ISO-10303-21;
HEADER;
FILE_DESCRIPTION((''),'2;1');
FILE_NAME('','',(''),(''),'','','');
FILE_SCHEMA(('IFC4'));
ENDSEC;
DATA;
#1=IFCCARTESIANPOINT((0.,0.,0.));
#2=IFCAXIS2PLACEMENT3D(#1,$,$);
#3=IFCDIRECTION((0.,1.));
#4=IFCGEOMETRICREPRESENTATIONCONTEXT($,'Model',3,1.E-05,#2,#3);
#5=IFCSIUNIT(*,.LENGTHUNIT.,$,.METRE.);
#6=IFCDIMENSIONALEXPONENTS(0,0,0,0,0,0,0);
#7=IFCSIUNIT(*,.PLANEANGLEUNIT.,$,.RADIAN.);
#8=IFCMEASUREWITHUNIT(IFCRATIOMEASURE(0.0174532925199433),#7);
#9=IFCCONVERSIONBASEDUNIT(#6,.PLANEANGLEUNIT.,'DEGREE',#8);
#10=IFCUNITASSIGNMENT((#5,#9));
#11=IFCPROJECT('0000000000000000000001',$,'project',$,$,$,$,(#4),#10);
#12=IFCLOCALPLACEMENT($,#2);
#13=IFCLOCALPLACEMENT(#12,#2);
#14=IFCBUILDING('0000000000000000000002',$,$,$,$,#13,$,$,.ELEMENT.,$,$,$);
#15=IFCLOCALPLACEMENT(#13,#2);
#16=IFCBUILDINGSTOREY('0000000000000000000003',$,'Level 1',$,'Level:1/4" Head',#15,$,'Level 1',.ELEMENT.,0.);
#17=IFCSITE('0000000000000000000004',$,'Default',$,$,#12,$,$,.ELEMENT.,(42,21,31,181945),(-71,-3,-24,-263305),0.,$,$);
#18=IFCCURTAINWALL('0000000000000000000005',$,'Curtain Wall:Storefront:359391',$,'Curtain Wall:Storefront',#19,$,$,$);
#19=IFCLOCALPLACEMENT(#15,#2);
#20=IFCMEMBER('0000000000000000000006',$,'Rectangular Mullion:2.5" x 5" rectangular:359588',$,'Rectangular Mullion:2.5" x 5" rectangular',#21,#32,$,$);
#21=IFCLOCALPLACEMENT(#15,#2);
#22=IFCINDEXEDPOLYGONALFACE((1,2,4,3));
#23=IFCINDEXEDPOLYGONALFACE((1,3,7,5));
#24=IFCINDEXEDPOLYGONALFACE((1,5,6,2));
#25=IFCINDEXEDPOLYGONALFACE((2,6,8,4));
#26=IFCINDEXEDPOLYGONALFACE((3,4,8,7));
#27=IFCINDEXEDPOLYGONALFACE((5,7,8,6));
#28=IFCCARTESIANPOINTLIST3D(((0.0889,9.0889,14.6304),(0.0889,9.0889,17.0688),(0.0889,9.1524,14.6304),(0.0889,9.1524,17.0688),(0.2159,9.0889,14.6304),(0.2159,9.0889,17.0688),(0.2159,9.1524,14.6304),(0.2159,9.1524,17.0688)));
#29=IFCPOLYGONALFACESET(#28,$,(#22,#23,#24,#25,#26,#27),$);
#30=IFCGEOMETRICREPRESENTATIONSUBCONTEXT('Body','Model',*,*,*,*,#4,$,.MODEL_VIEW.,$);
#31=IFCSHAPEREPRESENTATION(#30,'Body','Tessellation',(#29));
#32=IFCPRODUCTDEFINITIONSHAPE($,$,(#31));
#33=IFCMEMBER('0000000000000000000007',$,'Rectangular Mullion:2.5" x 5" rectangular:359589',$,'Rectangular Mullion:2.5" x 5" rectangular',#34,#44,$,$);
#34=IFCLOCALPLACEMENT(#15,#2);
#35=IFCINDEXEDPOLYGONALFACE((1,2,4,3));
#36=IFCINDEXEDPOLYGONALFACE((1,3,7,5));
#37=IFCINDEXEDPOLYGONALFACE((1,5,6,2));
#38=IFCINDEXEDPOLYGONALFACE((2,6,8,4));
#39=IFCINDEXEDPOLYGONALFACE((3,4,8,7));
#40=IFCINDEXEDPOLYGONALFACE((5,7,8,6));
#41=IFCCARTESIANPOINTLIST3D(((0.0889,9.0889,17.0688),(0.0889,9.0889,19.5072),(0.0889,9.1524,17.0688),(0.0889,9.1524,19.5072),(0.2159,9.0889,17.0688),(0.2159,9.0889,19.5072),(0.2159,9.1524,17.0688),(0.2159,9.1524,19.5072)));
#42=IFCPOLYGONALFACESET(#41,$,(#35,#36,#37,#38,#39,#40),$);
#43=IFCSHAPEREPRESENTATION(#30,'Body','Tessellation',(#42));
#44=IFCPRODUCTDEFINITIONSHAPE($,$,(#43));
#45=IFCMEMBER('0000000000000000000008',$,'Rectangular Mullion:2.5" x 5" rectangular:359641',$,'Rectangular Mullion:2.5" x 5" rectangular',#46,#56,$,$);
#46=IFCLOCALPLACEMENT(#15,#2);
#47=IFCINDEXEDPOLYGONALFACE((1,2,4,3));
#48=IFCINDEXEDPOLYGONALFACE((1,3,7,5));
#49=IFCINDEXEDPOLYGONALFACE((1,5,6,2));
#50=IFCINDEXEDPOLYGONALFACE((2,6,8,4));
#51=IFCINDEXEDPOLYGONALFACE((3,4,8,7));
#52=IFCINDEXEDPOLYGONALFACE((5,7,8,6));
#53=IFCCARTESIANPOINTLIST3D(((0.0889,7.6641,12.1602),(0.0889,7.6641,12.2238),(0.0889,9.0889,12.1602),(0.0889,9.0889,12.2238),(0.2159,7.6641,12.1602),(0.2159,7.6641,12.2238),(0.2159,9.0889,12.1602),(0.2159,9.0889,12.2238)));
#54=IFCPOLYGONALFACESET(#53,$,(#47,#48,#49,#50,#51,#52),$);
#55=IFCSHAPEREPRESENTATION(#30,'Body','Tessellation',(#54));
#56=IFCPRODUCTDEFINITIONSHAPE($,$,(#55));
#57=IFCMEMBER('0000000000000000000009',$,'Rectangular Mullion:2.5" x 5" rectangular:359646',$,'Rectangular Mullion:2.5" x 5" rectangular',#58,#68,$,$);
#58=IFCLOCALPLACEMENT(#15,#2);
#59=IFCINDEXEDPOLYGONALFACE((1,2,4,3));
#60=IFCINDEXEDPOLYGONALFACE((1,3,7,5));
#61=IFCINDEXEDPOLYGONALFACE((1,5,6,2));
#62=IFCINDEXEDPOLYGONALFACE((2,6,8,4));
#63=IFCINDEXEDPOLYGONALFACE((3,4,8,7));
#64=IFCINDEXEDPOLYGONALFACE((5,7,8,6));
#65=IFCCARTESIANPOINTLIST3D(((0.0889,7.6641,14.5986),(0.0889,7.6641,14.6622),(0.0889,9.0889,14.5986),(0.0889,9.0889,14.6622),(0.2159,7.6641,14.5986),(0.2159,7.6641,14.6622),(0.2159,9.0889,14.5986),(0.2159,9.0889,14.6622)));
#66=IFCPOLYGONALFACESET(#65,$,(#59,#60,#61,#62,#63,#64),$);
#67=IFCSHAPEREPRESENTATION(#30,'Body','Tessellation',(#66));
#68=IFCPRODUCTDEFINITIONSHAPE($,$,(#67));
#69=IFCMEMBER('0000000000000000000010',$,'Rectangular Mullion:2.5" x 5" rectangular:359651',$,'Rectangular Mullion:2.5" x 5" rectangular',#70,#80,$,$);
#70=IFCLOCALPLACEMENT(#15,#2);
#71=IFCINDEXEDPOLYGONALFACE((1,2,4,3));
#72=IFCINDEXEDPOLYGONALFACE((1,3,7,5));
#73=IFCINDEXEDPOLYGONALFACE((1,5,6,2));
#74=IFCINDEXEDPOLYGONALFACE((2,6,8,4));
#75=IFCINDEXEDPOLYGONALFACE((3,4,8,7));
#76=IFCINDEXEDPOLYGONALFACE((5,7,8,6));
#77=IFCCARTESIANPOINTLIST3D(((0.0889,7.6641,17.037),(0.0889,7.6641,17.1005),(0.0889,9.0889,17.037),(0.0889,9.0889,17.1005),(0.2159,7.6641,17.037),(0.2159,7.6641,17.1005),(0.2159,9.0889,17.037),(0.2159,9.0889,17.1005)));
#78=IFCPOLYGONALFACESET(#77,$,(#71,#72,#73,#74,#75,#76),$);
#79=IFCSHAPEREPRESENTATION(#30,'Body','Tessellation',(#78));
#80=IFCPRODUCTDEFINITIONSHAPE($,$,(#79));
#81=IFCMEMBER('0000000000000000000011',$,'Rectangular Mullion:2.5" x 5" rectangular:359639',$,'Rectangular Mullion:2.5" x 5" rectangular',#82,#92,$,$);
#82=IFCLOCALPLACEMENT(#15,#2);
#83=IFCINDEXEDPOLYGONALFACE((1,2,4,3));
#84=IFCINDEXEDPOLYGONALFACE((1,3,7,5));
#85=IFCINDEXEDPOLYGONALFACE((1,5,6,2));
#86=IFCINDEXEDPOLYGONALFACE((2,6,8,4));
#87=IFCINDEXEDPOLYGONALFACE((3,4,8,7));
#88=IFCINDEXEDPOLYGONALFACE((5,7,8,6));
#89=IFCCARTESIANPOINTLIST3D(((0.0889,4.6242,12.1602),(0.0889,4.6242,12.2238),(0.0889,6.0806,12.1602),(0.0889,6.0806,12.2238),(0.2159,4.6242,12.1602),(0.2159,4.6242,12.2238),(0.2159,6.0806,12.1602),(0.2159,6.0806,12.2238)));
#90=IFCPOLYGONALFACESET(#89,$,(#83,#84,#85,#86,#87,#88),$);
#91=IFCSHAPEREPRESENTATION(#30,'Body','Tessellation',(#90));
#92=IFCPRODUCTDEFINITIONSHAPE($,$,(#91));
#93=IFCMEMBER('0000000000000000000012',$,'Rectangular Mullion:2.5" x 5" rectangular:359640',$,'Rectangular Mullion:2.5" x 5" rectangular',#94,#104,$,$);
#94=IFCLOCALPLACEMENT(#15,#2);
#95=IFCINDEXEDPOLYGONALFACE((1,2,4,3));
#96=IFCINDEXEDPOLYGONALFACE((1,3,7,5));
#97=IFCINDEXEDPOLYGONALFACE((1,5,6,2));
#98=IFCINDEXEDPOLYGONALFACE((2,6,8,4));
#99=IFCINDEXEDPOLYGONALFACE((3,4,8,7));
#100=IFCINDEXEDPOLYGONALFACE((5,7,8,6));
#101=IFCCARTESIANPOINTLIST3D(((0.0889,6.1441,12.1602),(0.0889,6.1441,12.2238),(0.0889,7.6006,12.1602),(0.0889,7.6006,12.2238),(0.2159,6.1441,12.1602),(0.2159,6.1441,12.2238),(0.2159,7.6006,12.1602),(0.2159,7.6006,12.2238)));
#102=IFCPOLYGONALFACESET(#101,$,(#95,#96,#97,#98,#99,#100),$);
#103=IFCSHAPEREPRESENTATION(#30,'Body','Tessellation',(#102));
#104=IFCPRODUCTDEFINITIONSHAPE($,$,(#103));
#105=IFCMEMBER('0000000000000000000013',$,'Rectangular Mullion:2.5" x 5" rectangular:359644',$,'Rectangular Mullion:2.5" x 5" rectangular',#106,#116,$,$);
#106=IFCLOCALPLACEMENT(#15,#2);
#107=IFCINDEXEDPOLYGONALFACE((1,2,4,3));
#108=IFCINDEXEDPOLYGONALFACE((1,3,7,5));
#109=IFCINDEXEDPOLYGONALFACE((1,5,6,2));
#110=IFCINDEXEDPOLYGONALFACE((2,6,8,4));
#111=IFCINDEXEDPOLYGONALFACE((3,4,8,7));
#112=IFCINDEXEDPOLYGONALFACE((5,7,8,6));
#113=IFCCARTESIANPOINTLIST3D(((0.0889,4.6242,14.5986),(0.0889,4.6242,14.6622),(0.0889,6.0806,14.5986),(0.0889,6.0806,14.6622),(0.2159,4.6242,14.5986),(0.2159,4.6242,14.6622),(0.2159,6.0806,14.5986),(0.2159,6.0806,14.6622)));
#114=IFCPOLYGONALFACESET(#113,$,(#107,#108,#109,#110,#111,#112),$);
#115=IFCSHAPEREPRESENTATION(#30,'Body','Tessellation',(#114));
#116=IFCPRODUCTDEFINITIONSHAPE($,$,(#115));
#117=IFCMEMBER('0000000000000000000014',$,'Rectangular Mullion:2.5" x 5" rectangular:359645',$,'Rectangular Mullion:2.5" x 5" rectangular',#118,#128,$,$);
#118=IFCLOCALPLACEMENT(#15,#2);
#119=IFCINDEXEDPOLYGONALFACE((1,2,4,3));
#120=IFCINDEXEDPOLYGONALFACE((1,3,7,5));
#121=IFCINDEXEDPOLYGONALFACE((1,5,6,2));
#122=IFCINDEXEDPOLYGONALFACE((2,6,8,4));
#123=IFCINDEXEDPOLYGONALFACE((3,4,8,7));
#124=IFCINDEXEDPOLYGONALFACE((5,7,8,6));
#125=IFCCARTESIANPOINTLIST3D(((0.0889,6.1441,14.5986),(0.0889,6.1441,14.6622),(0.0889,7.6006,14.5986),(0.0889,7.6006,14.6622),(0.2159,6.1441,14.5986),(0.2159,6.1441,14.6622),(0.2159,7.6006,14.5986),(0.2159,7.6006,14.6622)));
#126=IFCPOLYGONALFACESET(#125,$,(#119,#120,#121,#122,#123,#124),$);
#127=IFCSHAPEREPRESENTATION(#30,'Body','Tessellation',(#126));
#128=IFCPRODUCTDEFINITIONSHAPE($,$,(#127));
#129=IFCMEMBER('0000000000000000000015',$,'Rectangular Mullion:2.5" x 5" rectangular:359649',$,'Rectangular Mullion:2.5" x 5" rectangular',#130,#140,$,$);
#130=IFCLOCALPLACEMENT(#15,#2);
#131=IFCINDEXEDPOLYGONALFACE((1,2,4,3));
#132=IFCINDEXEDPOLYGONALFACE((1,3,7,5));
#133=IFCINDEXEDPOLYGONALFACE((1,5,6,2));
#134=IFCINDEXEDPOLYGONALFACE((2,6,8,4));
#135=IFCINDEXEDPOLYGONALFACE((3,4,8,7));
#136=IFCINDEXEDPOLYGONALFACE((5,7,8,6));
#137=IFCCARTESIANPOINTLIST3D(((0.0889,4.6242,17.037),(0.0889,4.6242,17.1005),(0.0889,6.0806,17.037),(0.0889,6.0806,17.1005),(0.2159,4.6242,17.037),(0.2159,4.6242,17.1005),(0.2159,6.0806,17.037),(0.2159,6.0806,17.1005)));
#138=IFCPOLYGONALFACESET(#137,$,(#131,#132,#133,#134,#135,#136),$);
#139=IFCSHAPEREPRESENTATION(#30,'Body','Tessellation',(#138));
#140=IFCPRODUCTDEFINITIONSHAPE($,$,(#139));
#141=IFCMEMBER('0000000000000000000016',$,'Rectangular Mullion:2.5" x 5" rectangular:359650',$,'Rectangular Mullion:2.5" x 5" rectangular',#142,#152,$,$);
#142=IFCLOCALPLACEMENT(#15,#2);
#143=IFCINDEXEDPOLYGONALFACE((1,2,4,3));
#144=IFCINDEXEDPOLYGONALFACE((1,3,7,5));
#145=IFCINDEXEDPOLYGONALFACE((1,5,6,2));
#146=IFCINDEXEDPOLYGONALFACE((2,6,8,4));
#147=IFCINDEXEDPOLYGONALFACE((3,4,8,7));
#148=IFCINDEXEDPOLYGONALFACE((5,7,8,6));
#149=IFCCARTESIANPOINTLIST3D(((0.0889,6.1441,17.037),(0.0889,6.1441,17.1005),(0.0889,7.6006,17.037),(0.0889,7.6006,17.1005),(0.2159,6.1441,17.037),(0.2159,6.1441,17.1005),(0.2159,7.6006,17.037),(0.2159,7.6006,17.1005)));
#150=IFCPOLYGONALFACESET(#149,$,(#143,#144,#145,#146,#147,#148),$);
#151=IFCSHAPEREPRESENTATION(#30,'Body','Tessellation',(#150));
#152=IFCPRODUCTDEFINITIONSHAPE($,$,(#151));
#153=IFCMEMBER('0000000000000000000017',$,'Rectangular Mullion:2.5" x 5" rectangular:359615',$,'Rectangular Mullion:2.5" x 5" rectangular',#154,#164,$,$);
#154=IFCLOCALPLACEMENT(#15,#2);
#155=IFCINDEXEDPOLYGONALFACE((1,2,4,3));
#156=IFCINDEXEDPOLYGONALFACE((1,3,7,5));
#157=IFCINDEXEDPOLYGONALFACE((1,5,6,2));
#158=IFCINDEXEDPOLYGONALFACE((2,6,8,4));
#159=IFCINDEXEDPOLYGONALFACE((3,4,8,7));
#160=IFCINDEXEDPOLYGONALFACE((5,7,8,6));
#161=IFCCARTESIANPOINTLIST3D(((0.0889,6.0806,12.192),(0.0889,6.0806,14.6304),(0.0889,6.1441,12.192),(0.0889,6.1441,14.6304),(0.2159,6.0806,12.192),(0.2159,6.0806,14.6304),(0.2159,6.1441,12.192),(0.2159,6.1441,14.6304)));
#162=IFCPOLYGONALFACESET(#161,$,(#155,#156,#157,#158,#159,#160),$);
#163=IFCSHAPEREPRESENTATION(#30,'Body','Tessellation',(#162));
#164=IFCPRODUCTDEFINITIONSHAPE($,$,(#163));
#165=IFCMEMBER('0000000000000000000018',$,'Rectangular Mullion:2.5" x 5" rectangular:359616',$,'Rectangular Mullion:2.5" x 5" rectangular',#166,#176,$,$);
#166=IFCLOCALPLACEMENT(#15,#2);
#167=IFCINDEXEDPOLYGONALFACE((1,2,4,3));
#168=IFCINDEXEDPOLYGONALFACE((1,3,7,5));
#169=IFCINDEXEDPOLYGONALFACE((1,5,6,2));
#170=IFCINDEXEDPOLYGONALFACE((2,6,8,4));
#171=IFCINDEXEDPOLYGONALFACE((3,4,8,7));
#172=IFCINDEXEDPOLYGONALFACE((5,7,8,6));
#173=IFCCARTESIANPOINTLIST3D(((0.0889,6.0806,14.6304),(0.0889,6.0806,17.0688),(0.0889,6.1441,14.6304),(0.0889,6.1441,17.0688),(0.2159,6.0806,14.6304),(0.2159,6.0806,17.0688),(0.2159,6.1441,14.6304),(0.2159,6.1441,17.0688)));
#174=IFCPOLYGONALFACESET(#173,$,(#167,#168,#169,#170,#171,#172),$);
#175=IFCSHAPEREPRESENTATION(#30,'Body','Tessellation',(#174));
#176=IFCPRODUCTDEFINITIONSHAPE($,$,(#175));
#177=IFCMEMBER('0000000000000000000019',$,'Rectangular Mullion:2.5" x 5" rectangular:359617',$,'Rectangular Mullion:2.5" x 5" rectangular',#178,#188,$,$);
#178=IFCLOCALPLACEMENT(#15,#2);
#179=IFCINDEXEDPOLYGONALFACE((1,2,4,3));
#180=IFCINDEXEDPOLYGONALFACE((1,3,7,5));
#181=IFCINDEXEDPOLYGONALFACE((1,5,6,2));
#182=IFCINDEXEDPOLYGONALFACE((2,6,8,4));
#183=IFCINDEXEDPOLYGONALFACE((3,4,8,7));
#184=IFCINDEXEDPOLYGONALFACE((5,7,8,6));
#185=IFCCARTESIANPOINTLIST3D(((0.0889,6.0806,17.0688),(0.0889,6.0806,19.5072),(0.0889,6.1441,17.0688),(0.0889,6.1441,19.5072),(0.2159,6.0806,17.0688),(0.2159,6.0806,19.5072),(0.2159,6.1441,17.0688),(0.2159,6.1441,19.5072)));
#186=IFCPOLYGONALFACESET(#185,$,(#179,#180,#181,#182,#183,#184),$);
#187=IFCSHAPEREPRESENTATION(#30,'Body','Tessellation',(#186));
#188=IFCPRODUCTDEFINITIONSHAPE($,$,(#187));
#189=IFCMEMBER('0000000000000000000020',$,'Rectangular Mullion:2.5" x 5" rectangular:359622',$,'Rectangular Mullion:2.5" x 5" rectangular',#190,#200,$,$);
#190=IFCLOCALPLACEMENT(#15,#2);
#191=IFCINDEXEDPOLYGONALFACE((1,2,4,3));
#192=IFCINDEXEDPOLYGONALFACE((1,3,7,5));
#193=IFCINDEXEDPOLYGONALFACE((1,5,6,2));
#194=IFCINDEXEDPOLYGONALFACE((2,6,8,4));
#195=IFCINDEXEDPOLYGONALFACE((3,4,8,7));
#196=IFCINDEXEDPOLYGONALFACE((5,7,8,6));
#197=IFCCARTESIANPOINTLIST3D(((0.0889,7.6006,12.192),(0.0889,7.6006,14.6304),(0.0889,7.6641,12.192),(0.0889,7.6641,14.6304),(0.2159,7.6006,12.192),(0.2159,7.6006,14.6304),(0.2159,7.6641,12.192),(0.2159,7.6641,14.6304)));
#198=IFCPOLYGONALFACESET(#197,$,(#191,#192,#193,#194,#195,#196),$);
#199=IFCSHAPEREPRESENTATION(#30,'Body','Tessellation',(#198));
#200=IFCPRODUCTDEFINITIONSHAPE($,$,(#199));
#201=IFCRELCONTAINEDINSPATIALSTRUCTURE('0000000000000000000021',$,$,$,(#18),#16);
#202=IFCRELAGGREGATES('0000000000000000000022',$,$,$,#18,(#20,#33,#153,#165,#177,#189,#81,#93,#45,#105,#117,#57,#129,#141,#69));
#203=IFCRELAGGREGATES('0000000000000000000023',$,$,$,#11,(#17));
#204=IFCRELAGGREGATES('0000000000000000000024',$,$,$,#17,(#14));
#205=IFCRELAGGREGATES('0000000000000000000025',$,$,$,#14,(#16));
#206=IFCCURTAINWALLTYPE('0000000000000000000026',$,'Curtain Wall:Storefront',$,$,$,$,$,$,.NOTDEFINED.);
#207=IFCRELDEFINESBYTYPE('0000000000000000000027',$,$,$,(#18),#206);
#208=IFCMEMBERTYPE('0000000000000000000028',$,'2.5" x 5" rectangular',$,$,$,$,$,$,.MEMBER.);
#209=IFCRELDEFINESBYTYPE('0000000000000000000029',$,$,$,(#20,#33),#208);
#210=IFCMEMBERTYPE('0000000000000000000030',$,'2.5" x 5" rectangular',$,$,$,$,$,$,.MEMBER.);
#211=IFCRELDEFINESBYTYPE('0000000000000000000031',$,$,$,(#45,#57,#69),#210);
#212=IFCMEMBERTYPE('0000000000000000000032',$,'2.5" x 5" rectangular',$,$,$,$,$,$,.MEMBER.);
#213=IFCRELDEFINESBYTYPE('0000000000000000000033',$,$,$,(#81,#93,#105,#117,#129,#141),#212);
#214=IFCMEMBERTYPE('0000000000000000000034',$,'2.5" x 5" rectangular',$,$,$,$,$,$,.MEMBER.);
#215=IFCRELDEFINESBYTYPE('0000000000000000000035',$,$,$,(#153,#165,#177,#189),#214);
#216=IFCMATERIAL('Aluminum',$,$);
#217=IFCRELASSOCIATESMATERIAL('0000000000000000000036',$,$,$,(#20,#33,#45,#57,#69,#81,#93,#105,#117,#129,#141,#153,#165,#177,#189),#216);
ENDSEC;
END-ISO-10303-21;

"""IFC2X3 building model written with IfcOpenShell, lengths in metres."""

from ifc_helpers import new_model, entity, si_unit, converted_unit, direction, frame, origin, origin_2d_with_axis, place, context, subcontext, project, spatial, rectangle, extrude, source, transform, mapped, material, type_object, type_shapes, element, aggregate, save


model = new_model("IFC2X3")

# Units and contexts
model_context = context("Model", 3, precision=1e-05, world=origin(), true_north=direction((0.0, 1.0)))
body_context = subcontext(model_context, "Body", "Model", "MODEL_VIEW")
ifc_project = project(units=[si_unit("LENGTHUNIT", "METRE"), converted_unit("PLANEANGLEUNIT", "DEGREE", entity("IfcRatioMeasure", 0.0174532925199433), si_unit("PLANEANGLEUNIT", "RADIAN"), dimensions=[0, 0, 0, 0, 0, 0, 0])], contexts=[model_context])

# Site, building, storey
site_placement = place(None, origin())
site = spatial("IfcSite", under=ifc_project, at=site_placement, Name="Default", CompositionType="ELEMENT", RefLatitude=(42, 21, 31, 181945), RefLongitude=(-71, -3, -24, -263305), RefElevation=0.0)
building_placement = place(site_placement, origin())
building = spatial("IfcBuilding", under=site, at=building_placement, CompositionType="ELEMENT")
storey_placement = place(building_placement, origin())
storey = spatial("IfcBuildingStorey", under=building, at=storey_placement, Name="Level 1", ObjectType="Level:1/4\" Head", LongName="Level 1", CompositionType="ELEMENT", Elevation=0.0)

# Curtain wall, members
curtain_wall_type = type_object("IfcCurtainWallType", Name="Curtain Wall:Storefront", PredefinedType="NOTDEFINED")
curtain_wall_placement = place(storey_placement, origin())
curtain_wall = element("IfcCurtainWall", 1, at=curtain_wall_placement, inside=storey, type_object=curtain_wall_type, Name="Curtain Wall:Storefront:359391", ObjectType="Curtain Wall:Storefront")
ifc_material_1 = material(Name="Aluminum")
member_type_1 = type_object("IfcMemberType", Name="2.5\" x 5\" rectangular", PredefinedType="MEMBER")
shared_shape_1 = source(origin(), body_context, "Body", "SweptSolid", [
    extrude(rectangle(XDim=0.127, YDim=0.0635, at=origin_2d_with_axis()), frame((-0.0318, 0.0, -2.4384), z_axis=(0.0, 0.0, 1.0), x_axis=(0.0, -1.0, 0.0)), (0.0, 0.0, 1.0), 2.4384),
])
type_shapes(member_type_1, [shared_shape_1])
member_1_placement = place(storey_placement, frame((0.1524, 9.1524, 14.6304), z_axis=(0.0, 0.0, -1.0), x_axis=(0.0, 1.0, 0.0)))
member_1 = element("IfcMember", 2, at=member_1_placement, type_object=member_type_1, material=ifc_material_1, Name="Rectangular Mullion:2.5\" x 5\" rectangular:359588", ObjectType="Rectangular Mullion:2.5\" x 5\" rectangular", context=body_context, shape_type="MappedRepresentation", body=[
    mapped(shared_shape_1, transform((0.0, 0.0, 0.0), scale=1.0)),
])
member_2_placement = place(storey_placement, frame((0.1524, 9.1524, 17.0688), z_axis=(0.0, 0.0, -1.0), x_axis=(0.0, 1.0, 0.0)))
member_2 = element("IfcMember", 3, at=member_2_placement, type_object=member_type_1, material=ifc_material_1, Name="Rectangular Mullion:2.5\" x 5\" rectangular:359589", ObjectType="Rectangular Mullion:2.5\" x 5\" rectangular", context=body_context, shape_type="MappedRepresentation", body=[
    mapped(shared_shape_1, transform((0.0, 0.0, 0.0), scale=1.0)),
])
member_type_2 = type_object("IfcMemberType", Name="2.5\" x 5\" rectangular", PredefinedType="MEMBER")
shared_shape_2 = source(origin(), body_context, "Body", "SweptSolid", [
    extrude(rectangle(XDim=0.127, YDim=0.0635, at=origin_2d_with_axis()), frame((0.0, 0.0, -1.4248), z_axis=(0.0, 0.0, 1.0), x_axis=(0.0, -1.0, 0.0)), (0.0, 0.0, 1.0), 1.4248),
])
type_shapes(member_type_2, [shared_shape_2])
member_3_placement = place(storey_placement, frame((0.1524, 9.0889, 12.192), z_axis=(0.0, 1.0, 0.0), x_axis=(0.0, 0.0, 1.0)))
member_3 = element("IfcMember", 4, at=member_3_placement, type_object=member_type_2, material=ifc_material_1, Name="Rectangular Mullion:2.5\" x 5\" rectangular:359641", ObjectType="Rectangular Mullion:2.5\" x 5\" rectangular", context=body_context, shape_type="MappedRepresentation", body=[
    mapped(shared_shape_2, transform((0.0, 0.0, 0.0), scale=1.0)),
])
member_4_placement = place(storey_placement, frame((0.1524, 9.0889, 14.6304), z_axis=(0.0, 1.0, 0.0), x_axis=(0.0, 0.0, 1.0)))
member_4 = element("IfcMember", 5, at=member_4_placement, type_object=member_type_2, material=ifc_material_1, Name="Rectangular Mullion:2.5\" x 5\" rectangular:359646", ObjectType="Rectangular Mullion:2.5\" x 5\" rectangular", context=body_context, shape_type="MappedRepresentation", body=[
    mapped(shared_shape_2, transform((0.0, 0.0, 0.0), scale=1.0)),
])
member_5_placement = place(storey_placement, frame((0.1524, 9.0889, 17.0688), z_axis=(0.0, 1.0, 0.0), x_axis=(0.0, 0.0, 1.0)))
member_5 = element("IfcMember", 6, at=member_5_placement, type_object=member_type_2, material=ifc_material_1, Name="Rectangular Mullion:2.5\" x 5\" rectangular:359651", ObjectType="Rectangular Mullion:2.5\" x 5\" rectangular", context=body_context, shape_type="MappedRepresentation", body=[
    mapped(shared_shape_2, transform((0.0, 0.0, 0.0), scale=1.0)),
])
member_type_3 = type_object("IfcMemberType", Name="2.5\" x 5\" rectangular", PredefinedType="MEMBER")
shared_shape_3 = source(origin(), body_context, "Body", "SweptSolid", [
    extrude(rectangle(XDim=0.127, YDim=0.0635, at=origin_2d_with_axis()), frame((0.0, 0.0, -1.4565), z_axis=(0.0, 0.0, 1.0), x_axis=(0.0, -1.0, 0.0)), (0.0, 0.0, 1.0), 1.4565),
])
type_shapes(member_type_3, [shared_shape_3])
member_6_placement = place(storey_placement, frame((0.1524, 6.0806, 12.192), z_axis=(0.0, 1.0, 0.0), x_axis=(0.0, 0.0, 1.0)))
member_6 = element("IfcMember", 7, at=member_6_placement, type_object=member_type_3, material=ifc_material_1, Name="Rectangular Mullion:2.5\" x 5\" rectangular:359639", ObjectType="Rectangular Mullion:2.5\" x 5\" rectangular", context=body_context, shape_type="MappedRepresentation", body=[
    mapped(shared_shape_3, transform((0.0, 0.0, 0.0), scale=1.0)),
])
member_7_placement = place(storey_placement, frame((0.1524, 7.6006, 12.192), z_axis=(0.0, 1.0, 0.0), x_axis=(0.0, 0.0, 1.0)))
member_7 = element("IfcMember", 8, at=member_7_placement, type_object=member_type_3, material=ifc_material_1, Name="Rectangular Mullion:2.5\" x 5\" rectangular:359640", ObjectType="Rectangular Mullion:2.5\" x 5\" rectangular", context=body_context, shape_type="MappedRepresentation", body=[
    mapped(shared_shape_3, transform((0.0, 0.0, 0.0), scale=1.0)),
])
member_8_placement = place(storey_placement, frame((0.1524, 6.0806, 14.6304), z_axis=(0.0, 1.0, 0.0), x_axis=(0.0, 0.0, 1.0)))
member_8 = element("IfcMember", 9, at=member_8_placement, type_object=member_type_3, material=ifc_material_1, Name="Rectangular Mullion:2.5\" x 5\" rectangular:359644", ObjectType="Rectangular Mullion:2.5\" x 5\" rectangular", context=body_context, shape_type="MappedRepresentation", body=[
    mapped(shared_shape_3, transform((0.0, 0.0, 0.0), scale=1.0)),
])
member_9_placement = place(storey_placement, frame((0.1524, 7.6006, 14.6304), z_axis=(0.0, 1.0, 0.0), x_axis=(0.0, 0.0, 1.0)))
member_9 = element("IfcMember", 10, at=member_9_placement, type_object=member_type_3, material=ifc_material_1, Name="Rectangular Mullion:2.5\" x 5\" rectangular:359645", ObjectType="Rectangular Mullion:2.5\" x 5\" rectangular", context=body_context, shape_type="MappedRepresentation", body=[
    mapped(shared_shape_3, transform((0.0, 0.0, 0.0), scale=1.0)),
])
member_10_placement = place(storey_placement, frame((0.1524, 6.0806, 17.0688), z_axis=(0.0, 1.0, 0.0), x_axis=(0.0, 0.0, 1.0)))
member_10 = element("IfcMember", 11, at=member_10_placement, type_object=member_type_3, material=ifc_material_1, Name="Rectangular Mullion:2.5\" x 5\" rectangular:359649", ObjectType="Rectangular Mullion:2.5\" x 5\" rectangular", context=body_context, shape_type="MappedRepresentation", body=[
    mapped(shared_shape_3, transform((0.0, 0.0, 0.0), scale=1.0)),
])
member_11_placement = place(storey_placement, frame((0.1524, 7.6006, 17.0688), z_axis=(0.0, 1.0, 0.0), x_axis=(0.0, 0.0, 1.0)))
member_11 = element("IfcMember", 12, at=member_11_placement, type_object=member_type_3, material=ifc_material_1, Name="Rectangular Mullion:2.5\" x 5\" rectangular:359650", ObjectType="Rectangular Mullion:2.5\" x 5\" rectangular", context=body_context, shape_type="MappedRepresentation", body=[
    mapped(shared_shape_3, transform((0.0, 0.0, 0.0), scale=1.0)),
])
member_type_4 = type_object("IfcMemberType", Name="2.5\" x 5\" rectangular", PredefinedType="MEMBER")
shared_shape_4 = source(origin(), body_context, "Body", "SweptSolid", [
    extrude(rectangle(XDim=0.127, YDim=0.0635, at=origin_2d_with_axis()), frame((0.0, 0.0, -2.4384), z_axis=(0.0, 0.0, 1.0), x_axis=(0.0, -1.0, 0.0)), (0.0, 0.0, 1.0), 2.4384),
])
type_shapes(member_type_4, [shared_shape_4])
member_12_placement = place(storey_placement, frame((0.1524, 6.1124, 12.192), z_axis=(0.0, 0.0, -1.0), x_axis=(0.0, 1.0, 0.0)))
member_12 = element("IfcMember", 13, at=member_12_placement, type_object=member_type_4, material=ifc_material_1, Name="Rectangular Mullion:2.5\" x 5\" rectangular:359615", ObjectType="Rectangular Mullion:2.5\" x 5\" rectangular", context=body_context, shape_type="MappedRepresentation", body=[
    mapped(shared_shape_4, transform((0.0, 0.0, 0.0), scale=1.0)),
])
member_13_placement = place(storey_placement, frame((0.1524, 6.1124, 14.6304), z_axis=(0.0, 0.0, -1.0), x_axis=(0.0, 1.0, 0.0)))
member_13 = element("IfcMember", 14, at=member_13_placement, type_object=member_type_4, material=ifc_material_1, Name="Rectangular Mullion:2.5\" x 5\" rectangular:359616", ObjectType="Rectangular Mullion:2.5\" x 5\" rectangular", context=body_context, shape_type="MappedRepresentation", body=[
    mapped(shared_shape_4, transform((0.0, 0.0, 0.0), scale=1.0)),
])
member_14_placement = place(storey_placement, frame((0.1524, 6.1124, 17.0688), z_axis=(0.0, 0.0, -1.0), x_axis=(0.0, 1.0, 0.0)))
member_14 = element("IfcMember", 15, at=member_14_placement, type_object=member_type_4, material=ifc_material_1, Name="Rectangular Mullion:2.5\" x 5\" rectangular:359617", ObjectType="Rectangular Mullion:2.5\" x 5\" rectangular", context=body_context, shape_type="MappedRepresentation", body=[
    mapped(shared_shape_4, transform((0.0, 0.0, 0.0), scale=1.0)),
])
member_15_placement = place(storey_placement, frame((0.1524, 7.6324, 12.192), z_axis=(0.0, 0.0, -1.0), x_axis=(0.0, 1.0, 0.0)))
member_15 = element("IfcMember", 16, at=member_15_placement, type_object=member_type_4, material=ifc_material_1, Name="Rectangular Mullion:2.5\" x 5\" rectangular:359622", ObjectType="Rectangular Mullion:2.5\" x 5\" rectangular", context=body_context, shape_type="MappedRepresentation", body=[
    mapped(shared_shape_4, transform((0.0, 0.0, 0.0), scale=1.0)),
])
aggregate(curtain_wall, [member_1, member_2, member_12, member_13, member_14, member_15, member_6, member_7, member_3, member_8, member_9, member_4, member_10, member_11, member_5])

save(model, "model.ifc")
